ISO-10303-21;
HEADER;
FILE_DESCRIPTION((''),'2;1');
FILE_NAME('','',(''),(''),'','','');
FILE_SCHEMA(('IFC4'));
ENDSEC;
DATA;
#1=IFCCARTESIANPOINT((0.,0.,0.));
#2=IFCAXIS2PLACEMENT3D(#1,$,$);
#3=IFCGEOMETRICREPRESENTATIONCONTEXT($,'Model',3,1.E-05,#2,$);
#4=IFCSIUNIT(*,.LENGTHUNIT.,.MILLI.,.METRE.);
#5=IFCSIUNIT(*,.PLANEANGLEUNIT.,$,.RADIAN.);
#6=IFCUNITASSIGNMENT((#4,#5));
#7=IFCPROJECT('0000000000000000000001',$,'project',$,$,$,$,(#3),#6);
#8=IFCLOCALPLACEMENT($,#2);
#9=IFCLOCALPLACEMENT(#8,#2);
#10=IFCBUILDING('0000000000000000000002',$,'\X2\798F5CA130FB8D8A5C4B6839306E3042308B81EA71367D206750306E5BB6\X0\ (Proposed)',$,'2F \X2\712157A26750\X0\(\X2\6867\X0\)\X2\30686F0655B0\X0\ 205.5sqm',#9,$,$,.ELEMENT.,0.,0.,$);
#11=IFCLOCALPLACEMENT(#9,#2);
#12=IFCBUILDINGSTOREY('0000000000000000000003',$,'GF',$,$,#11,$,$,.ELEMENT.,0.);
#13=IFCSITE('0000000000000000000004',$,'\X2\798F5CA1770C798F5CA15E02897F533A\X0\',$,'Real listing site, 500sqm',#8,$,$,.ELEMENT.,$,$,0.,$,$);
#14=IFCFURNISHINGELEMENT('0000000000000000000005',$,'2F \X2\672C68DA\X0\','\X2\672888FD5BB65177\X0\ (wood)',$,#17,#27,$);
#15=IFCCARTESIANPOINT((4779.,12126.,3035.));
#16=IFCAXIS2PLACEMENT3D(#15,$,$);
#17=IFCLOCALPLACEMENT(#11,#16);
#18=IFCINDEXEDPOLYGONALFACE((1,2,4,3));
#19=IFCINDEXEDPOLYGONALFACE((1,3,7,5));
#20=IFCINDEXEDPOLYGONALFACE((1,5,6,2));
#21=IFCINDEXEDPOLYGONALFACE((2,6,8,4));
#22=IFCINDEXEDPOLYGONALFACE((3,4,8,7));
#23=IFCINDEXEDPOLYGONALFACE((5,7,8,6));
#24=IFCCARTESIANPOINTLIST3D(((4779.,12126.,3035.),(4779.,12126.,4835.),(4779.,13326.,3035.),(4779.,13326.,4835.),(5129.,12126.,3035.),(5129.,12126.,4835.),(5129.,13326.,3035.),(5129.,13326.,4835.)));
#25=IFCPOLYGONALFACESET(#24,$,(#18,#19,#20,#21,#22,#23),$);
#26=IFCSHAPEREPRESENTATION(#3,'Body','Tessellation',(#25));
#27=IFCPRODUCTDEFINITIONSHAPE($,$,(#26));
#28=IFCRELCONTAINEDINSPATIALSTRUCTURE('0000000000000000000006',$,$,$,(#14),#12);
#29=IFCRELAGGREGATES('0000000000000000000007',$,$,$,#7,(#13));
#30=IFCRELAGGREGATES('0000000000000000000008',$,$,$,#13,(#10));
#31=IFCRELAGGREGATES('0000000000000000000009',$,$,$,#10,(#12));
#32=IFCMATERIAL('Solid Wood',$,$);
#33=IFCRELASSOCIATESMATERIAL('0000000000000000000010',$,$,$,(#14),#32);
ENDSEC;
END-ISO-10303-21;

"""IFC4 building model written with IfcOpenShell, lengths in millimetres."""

from ifc_helpers import new_model, si_unit, frame, frame_2d, origin, place, context, project, spatial, rectangle, extrude, material, element, save


model = new_model("IFC4")

# Units and contexts
model_context = context("Model", 3, precision=1e-05, world=origin())
ifc_project = project(units=[si_unit("LENGTHUNIT", "METRE", prefix="MILLI"), si_unit("PLANEANGLEUNIT", "RADIAN")], contexts=[model_context])

# Site, building, storey
site_placement = place(None, origin())
site = spatial("IfcSite", under=ifc_project, at=site_placement, Name="福岡県福岡市西区", ObjectType="Real listing site, 500sqm", CompositionType="ELEMENT", RefElevation=0.0)
building_placement = place(site_placement, origin())
building = spatial("IfcBuilding", under=site, at=building_placement, Name="福岡・越屋根のある自然素材の家 (Proposed)", ObjectType="2F 無垢材(桧)と漆喰 205.5sqm", CompositionType="ELEMENT", ElevationOfRefHeight=0.0, ElevationOfTerrain=0.0)
storey_placement = place(building_placement, origin())
storey = spatial("IfcBuildingStorey", under=building, at=storey_placement, Name="GF", CompositionType="ELEMENT", Elevation=0.0)

# Shared definitions
ifc_material_1 = material(Name="Solid Wood")

# Furnishing element
furnishing_1_placement = place(storey_placement, frame((4779.0, 12126.0, 3035.0)))
element("IfcFurnishingElement", 1, at=furnishing_1_placement, inside=storey, material=ifc_material_1, Name="2F 本棚", Description="木製家具 (wood)", context=model_context, shape_type="SweptSolid", body=[
    extrude(rectangle(XDim=350.0, YDim=1200.0, at=frame_2d((175.0, 600.0))), frame((4779.0, 12126.0, 3035.0)), (0.0, 0.0, 1.0), 1800.0),
])

save(model, "model.ifc")
